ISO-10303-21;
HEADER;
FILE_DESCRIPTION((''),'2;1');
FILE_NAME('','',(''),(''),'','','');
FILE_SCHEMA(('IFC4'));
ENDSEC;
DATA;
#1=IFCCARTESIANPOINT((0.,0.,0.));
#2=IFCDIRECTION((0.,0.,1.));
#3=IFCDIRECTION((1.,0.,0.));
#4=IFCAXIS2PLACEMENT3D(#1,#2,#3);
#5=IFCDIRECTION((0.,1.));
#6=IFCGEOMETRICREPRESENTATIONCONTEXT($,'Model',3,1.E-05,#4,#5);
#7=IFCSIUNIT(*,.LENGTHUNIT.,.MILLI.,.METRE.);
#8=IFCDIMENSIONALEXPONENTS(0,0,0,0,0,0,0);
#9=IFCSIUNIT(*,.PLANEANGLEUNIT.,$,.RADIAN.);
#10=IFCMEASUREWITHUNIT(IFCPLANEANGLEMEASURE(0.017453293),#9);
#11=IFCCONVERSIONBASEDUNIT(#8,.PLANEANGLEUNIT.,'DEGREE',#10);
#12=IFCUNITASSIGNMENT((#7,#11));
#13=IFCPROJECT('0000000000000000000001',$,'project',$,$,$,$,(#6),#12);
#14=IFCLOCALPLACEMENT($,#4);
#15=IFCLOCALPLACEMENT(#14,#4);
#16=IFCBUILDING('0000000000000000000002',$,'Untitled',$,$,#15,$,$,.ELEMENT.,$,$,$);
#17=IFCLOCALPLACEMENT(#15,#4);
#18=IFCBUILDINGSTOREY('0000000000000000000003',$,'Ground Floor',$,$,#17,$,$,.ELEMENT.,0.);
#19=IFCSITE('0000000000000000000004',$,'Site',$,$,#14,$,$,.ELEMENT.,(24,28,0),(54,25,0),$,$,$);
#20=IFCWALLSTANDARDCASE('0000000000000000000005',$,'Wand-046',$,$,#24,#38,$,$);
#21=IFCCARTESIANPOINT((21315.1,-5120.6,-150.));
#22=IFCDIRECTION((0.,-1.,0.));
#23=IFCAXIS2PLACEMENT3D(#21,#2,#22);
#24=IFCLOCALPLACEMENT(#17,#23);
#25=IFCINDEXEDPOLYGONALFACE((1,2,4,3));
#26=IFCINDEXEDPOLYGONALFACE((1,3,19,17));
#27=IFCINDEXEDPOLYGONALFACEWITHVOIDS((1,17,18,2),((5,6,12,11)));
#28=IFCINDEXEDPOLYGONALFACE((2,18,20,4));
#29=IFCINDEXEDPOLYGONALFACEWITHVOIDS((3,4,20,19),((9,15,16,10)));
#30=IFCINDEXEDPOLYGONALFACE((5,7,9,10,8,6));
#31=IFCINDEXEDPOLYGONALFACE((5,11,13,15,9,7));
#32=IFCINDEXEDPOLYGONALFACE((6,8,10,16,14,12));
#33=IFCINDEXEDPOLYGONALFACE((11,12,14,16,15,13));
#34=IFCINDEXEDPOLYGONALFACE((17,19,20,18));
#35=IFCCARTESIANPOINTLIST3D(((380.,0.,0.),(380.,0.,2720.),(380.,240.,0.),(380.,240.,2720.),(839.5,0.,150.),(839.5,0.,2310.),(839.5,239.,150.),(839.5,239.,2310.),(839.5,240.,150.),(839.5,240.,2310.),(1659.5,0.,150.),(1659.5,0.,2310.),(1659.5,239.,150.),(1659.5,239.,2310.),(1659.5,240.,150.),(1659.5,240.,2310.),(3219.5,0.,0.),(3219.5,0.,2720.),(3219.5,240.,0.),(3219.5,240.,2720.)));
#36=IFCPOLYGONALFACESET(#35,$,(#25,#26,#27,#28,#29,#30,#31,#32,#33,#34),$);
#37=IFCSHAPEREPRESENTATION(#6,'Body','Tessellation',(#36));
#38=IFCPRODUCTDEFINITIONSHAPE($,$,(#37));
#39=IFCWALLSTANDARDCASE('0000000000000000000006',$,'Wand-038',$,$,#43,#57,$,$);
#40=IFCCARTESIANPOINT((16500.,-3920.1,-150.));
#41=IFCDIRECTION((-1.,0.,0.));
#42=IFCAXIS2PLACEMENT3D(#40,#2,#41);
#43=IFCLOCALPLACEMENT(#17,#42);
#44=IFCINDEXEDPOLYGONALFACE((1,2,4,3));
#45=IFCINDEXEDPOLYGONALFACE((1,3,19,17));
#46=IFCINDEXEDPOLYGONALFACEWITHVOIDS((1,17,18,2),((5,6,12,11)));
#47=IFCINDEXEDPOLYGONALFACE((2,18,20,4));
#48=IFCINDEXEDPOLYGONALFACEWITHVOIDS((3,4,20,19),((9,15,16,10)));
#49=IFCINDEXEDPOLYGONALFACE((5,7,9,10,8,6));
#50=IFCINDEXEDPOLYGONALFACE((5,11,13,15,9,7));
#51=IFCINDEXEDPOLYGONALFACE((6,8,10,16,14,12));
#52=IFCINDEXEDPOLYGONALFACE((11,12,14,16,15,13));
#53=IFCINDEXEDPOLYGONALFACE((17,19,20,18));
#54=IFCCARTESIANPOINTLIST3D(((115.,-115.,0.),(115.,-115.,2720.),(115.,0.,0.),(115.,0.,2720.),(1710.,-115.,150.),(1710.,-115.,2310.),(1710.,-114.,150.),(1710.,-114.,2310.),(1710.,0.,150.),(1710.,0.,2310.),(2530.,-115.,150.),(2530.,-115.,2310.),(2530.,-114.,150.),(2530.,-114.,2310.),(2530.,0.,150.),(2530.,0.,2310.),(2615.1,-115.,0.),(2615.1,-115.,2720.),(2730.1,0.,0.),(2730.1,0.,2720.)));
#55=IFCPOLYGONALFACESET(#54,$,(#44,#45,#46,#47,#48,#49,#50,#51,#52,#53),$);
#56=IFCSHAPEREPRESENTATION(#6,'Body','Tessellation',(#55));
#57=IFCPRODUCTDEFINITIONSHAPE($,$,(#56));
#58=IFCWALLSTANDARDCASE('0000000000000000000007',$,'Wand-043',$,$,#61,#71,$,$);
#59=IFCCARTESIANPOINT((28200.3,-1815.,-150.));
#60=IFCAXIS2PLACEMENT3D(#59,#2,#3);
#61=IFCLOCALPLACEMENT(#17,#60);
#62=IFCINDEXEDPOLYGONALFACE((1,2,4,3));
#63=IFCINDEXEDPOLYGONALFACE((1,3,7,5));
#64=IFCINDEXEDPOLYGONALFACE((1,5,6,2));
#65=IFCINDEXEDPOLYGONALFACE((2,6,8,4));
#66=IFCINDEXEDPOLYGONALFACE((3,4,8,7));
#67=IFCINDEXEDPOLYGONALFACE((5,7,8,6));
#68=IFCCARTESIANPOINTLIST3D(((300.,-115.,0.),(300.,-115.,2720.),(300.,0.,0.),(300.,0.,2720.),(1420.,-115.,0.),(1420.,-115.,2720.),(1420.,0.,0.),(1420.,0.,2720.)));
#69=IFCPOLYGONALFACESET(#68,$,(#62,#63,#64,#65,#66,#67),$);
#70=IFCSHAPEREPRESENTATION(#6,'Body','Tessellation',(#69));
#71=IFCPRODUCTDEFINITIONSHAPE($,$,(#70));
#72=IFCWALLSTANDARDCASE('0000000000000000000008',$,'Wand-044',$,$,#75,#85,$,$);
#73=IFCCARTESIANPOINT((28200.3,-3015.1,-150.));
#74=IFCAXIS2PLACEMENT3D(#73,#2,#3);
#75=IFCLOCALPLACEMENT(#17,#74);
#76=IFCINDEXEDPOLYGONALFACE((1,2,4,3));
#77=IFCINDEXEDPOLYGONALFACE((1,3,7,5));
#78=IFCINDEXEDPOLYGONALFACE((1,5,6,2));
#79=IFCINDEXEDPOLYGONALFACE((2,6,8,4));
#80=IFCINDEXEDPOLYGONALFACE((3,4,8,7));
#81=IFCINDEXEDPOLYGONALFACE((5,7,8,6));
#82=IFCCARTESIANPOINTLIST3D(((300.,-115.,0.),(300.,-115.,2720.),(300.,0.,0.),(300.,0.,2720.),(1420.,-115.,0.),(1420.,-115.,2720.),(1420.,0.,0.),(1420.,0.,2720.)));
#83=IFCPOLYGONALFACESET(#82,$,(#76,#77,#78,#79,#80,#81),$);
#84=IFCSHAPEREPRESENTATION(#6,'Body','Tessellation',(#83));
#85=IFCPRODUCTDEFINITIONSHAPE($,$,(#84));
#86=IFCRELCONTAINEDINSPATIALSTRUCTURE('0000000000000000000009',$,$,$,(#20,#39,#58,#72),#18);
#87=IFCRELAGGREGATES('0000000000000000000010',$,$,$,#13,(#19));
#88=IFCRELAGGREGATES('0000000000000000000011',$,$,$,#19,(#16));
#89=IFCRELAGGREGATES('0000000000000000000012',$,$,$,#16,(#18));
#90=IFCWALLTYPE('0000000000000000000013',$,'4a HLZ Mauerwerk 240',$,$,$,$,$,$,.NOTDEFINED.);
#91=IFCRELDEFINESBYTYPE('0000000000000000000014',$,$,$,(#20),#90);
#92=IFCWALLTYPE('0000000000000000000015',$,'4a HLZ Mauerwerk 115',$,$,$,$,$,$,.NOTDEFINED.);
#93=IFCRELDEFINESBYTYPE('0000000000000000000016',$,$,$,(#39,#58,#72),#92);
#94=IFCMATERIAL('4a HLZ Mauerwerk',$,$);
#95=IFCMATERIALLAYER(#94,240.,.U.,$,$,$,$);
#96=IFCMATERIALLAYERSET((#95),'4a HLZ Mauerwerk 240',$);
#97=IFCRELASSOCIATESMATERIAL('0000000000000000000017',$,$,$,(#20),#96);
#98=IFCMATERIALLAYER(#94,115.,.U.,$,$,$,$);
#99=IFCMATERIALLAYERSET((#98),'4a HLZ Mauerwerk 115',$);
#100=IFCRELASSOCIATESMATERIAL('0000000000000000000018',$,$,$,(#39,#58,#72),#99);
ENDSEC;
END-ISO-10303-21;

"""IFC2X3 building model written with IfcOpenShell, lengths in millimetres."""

from ifc_helpers import new_model, entity, si_unit, converted_unit, direction, frame, origin_with_axes, origin_2d_with_axis, place, context, project, spatial, polyline, rectangle, outline, extrude, material, layer, layer_set, layer_usage, type_object, element, save


model = new_model("IFC2X3")

# Units and contexts
model_context = context("Model", 3, precision=1e-05, world=origin_with_axes(), true_north=direction((0.0, 1.0)))
ifc_project = project(units=[si_unit("LENGTHUNIT", "METRE", prefix="MILLI"), converted_unit("PLANEANGLEUNIT", "DEGREE", entity("IfcPlaneAngleMeasure", 0.017453293), si_unit("PLANEANGLEUNIT", "RADIAN"), dimensions=[0, 0, 0, 0, 0, 0, 0])], contexts=[model_context])

# Site, building, storey
site_placement = place(None, origin_with_axes())
site = spatial("IfcSite", under=ifc_project, at=site_placement, Name="Site", CompositionType="ELEMENT", RefLatitude=(24, 28, 0), RefLongitude=(54, 25, 0))
building_placement = place(site_placement, origin_with_axes())
building = spatial("IfcBuilding", under=site, at=building_placement, Name="Untitled", CompositionType="ELEMENT")
storey_placement = place(building_placement, origin_with_axes())
storey = spatial("IfcBuildingStorey", under=building, at=storey_placement, Name="Ground Floor", CompositionType="ELEMENT", Elevation=0.0)

# Shared definitions
ifc_material = material(Name="4a HLZ Mauerwerk")

# Wall, opening
ifc_layer_1 = layer(ifc_material, 240.0, ventilated="UNKNOWN")
ifc_layer_set_1 = layer_set([ifc_layer_1], Name="4a HLZ Mauerwerk 240")
ifc_layer_usage_1 = layer_usage(ifc_layer_set_1, "AXIS2", "POSITIVE", 0.0)
wall_type_1 = type_object("IfcWallType", Name="4a HLZ Mauerwerk 240", PredefinedType="NOTDEFINED")
wall_1_placement = place(storey_placement, frame((21315.1, -5120.6, -150.0), z_axis=(0.0, 0.0, 1.0), x_axis=(0.0, -1.0, 0.0)))
wall_1 = element("IfcWallStandardCase", 1, at=wall_1_placement, inside=storey, type_object=wall_type_1, material=ifc_layer_usage_1, Name="Wand-046", context=model_context, shape_type="SweptSolid", body=[
    extrude(outline(polyline([(380.0, 0.0), (3219.5, 0.0), (3219.5, 240.0), (380.0, 240.0), (380.0, 0.0)])), origin_with_axes(), (0.0, 0.0, 1.0), 2720.0),
])
opening_1_placement = place(wall_1_placement, frame((1249.5, 0.0, 150.0), z_axis=(0.0, 0.0, 1.0), x_axis=(1.0, 0.0, 0.0)))
element("IfcOpeningElement", 2, at=opening_1_placement, cuts=wall_1, context=model_context, shape_type="SweptSolid", body=[
    extrude(rectangle(XDim=820.0, YDim=2160.0, at=origin_2d_with_axis()), frame((0.0, 721.0, 1080.0), z_axis=(0.0, -1.0, 0.0), x_axis=(1.0, 0.0, 0.0)), (0.0, 0.0, 1.0), 482.0),
    extrude(rectangle(XDim=820.0, YDim=2160.0, at=origin_2d_with_axis()), frame((0.0, -241.0, 1080.0), z_axis=(0.0, 1.0, 0.0), x_axis=(1.0, 0.0, 0.0)), (0.0, 0.0, 1.0), 482.0),
])

# Wall, opening
ifc_layer_2 = layer(ifc_material, 115.0, ventilated="UNKNOWN")
ifc_layer_set_2 = layer_set([ifc_layer_2], Name="4a HLZ Mauerwerk 115")
wall_type_2 = type_object("IfcWallType", Name="4a HLZ Mauerwerk 115", PredefinedType="NOTDEFINED")
ifc_layer_usage_2 = layer_usage(ifc_layer_set_2, "AXIS2", "NEGATIVE", 0.0)
wall_2_placement = place(storey_placement, frame((16500.0, -3920.1, -150.0), z_axis=(0.0, 0.0, 1.0), x_axis=(-1.0, 0.0, 0.0)))
wall_2 = element("IfcWallStandardCase", 3, at=wall_2_placement, inside=storey, type_object=wall_type_2, material=ifc_layer_usage_2, Name="Wand-038", context=model_context, shape_type="SweptSolid", body=[
    extrude(outline(polyline([(115.0, -115.0), (2615.1, -115.0), (2730.1, 0.0), (115.0, 0.0), (115.0, -115.0)])), origin_with_axes(), (0.0, 0.0, 1.0), 2720.0),
])
opening_2_placement = place(wall_2_placement, frame((2120.0, 0.0, 150.0), z_axis=(0.0, 0.0, 1.0), x_axis=(1.0, 0.0, 0.0)))
element("IfcOpeningElement", 4, at=opening_2_placement, cuts=wall_2, context=model_context, shape_type="SweptSolid", body=[
    extrude(rectangle(XDim=820.0, YDim=2160.0, at=origin_2d_with_axis()), frame((0.0, -346.0, 1080.0), z_axis=(0.0, 1.0, 0.0), x_axis=(1.0, 0.0, 0.0)), (0.0, 0.0, 1.0), 232.0),
    extrude(rectangle(XDim=820.0, YDim=2160.0, at=origin_2d_with_axis()), frame((0.0, 116.0, 1080.0), z_axis=(0.0, -1.0, 0.0), x_axis=(1.0, 0.0, 0.0)), (0.0, 0.0, 1.0), 232.0),
])

# Walls
ifc_layer_usage_3 = layer_usage(ifc_layer_set_2, "AXIS2", "NEGATIVE", 0.0)
wall_3_placement = place(storey_placement, frame((28200.3, -1815.0, -150.0), z_axis=(0.0, 0.0, 1.0), x_axis=(1.0, 0.0, 0.0)))
element("IfcWallStandardCase", 5, at=wall_3_placement, inside=storey, type_object=wall_type_2, material=ifc_layer_usage_3, Name="Wand-043", context=model_context, shape_type="SweptSolid", body=[
    extrude(outline(polyline([(300.0, -115.0), (1420.0, -115.0), (1420.0, 0.0), (300.0, 0.0), (300.0, -115.0)])), origin_with_axes(), (0.0, 0.0, 1.0), 2720.0),
])
ifc_layer_usage_4 = layer_usage(ifc_layer_set_2, "AXIS2", "NEGATIVE", 0.0)
wall_4_placement = place(storey_placement, frame((28200.3, -3015.1, -150.0), z_axis=(0.0, 0.0, 1.0), x_axis=(1.0, 0.0, 0.0)))
element("IfcWallStandardCase", 6, at=wall_4_placement, inside=storey, type_object=wall_type_2, material=ifc_layer_usage_4, Name="Wand-044", context=model_context, shape_type="SweptSolid", body=[
    extrude(outline(polyline([(300.0, -115.0), (1420.0, -115.0), (1420.0, 0.0), (300.0, 0.0), (300.0, -115.0)])), origin_with_axes(), (0.0, 0.0, 1.0), 2720.0),
])

save(model, "model.ifc")
